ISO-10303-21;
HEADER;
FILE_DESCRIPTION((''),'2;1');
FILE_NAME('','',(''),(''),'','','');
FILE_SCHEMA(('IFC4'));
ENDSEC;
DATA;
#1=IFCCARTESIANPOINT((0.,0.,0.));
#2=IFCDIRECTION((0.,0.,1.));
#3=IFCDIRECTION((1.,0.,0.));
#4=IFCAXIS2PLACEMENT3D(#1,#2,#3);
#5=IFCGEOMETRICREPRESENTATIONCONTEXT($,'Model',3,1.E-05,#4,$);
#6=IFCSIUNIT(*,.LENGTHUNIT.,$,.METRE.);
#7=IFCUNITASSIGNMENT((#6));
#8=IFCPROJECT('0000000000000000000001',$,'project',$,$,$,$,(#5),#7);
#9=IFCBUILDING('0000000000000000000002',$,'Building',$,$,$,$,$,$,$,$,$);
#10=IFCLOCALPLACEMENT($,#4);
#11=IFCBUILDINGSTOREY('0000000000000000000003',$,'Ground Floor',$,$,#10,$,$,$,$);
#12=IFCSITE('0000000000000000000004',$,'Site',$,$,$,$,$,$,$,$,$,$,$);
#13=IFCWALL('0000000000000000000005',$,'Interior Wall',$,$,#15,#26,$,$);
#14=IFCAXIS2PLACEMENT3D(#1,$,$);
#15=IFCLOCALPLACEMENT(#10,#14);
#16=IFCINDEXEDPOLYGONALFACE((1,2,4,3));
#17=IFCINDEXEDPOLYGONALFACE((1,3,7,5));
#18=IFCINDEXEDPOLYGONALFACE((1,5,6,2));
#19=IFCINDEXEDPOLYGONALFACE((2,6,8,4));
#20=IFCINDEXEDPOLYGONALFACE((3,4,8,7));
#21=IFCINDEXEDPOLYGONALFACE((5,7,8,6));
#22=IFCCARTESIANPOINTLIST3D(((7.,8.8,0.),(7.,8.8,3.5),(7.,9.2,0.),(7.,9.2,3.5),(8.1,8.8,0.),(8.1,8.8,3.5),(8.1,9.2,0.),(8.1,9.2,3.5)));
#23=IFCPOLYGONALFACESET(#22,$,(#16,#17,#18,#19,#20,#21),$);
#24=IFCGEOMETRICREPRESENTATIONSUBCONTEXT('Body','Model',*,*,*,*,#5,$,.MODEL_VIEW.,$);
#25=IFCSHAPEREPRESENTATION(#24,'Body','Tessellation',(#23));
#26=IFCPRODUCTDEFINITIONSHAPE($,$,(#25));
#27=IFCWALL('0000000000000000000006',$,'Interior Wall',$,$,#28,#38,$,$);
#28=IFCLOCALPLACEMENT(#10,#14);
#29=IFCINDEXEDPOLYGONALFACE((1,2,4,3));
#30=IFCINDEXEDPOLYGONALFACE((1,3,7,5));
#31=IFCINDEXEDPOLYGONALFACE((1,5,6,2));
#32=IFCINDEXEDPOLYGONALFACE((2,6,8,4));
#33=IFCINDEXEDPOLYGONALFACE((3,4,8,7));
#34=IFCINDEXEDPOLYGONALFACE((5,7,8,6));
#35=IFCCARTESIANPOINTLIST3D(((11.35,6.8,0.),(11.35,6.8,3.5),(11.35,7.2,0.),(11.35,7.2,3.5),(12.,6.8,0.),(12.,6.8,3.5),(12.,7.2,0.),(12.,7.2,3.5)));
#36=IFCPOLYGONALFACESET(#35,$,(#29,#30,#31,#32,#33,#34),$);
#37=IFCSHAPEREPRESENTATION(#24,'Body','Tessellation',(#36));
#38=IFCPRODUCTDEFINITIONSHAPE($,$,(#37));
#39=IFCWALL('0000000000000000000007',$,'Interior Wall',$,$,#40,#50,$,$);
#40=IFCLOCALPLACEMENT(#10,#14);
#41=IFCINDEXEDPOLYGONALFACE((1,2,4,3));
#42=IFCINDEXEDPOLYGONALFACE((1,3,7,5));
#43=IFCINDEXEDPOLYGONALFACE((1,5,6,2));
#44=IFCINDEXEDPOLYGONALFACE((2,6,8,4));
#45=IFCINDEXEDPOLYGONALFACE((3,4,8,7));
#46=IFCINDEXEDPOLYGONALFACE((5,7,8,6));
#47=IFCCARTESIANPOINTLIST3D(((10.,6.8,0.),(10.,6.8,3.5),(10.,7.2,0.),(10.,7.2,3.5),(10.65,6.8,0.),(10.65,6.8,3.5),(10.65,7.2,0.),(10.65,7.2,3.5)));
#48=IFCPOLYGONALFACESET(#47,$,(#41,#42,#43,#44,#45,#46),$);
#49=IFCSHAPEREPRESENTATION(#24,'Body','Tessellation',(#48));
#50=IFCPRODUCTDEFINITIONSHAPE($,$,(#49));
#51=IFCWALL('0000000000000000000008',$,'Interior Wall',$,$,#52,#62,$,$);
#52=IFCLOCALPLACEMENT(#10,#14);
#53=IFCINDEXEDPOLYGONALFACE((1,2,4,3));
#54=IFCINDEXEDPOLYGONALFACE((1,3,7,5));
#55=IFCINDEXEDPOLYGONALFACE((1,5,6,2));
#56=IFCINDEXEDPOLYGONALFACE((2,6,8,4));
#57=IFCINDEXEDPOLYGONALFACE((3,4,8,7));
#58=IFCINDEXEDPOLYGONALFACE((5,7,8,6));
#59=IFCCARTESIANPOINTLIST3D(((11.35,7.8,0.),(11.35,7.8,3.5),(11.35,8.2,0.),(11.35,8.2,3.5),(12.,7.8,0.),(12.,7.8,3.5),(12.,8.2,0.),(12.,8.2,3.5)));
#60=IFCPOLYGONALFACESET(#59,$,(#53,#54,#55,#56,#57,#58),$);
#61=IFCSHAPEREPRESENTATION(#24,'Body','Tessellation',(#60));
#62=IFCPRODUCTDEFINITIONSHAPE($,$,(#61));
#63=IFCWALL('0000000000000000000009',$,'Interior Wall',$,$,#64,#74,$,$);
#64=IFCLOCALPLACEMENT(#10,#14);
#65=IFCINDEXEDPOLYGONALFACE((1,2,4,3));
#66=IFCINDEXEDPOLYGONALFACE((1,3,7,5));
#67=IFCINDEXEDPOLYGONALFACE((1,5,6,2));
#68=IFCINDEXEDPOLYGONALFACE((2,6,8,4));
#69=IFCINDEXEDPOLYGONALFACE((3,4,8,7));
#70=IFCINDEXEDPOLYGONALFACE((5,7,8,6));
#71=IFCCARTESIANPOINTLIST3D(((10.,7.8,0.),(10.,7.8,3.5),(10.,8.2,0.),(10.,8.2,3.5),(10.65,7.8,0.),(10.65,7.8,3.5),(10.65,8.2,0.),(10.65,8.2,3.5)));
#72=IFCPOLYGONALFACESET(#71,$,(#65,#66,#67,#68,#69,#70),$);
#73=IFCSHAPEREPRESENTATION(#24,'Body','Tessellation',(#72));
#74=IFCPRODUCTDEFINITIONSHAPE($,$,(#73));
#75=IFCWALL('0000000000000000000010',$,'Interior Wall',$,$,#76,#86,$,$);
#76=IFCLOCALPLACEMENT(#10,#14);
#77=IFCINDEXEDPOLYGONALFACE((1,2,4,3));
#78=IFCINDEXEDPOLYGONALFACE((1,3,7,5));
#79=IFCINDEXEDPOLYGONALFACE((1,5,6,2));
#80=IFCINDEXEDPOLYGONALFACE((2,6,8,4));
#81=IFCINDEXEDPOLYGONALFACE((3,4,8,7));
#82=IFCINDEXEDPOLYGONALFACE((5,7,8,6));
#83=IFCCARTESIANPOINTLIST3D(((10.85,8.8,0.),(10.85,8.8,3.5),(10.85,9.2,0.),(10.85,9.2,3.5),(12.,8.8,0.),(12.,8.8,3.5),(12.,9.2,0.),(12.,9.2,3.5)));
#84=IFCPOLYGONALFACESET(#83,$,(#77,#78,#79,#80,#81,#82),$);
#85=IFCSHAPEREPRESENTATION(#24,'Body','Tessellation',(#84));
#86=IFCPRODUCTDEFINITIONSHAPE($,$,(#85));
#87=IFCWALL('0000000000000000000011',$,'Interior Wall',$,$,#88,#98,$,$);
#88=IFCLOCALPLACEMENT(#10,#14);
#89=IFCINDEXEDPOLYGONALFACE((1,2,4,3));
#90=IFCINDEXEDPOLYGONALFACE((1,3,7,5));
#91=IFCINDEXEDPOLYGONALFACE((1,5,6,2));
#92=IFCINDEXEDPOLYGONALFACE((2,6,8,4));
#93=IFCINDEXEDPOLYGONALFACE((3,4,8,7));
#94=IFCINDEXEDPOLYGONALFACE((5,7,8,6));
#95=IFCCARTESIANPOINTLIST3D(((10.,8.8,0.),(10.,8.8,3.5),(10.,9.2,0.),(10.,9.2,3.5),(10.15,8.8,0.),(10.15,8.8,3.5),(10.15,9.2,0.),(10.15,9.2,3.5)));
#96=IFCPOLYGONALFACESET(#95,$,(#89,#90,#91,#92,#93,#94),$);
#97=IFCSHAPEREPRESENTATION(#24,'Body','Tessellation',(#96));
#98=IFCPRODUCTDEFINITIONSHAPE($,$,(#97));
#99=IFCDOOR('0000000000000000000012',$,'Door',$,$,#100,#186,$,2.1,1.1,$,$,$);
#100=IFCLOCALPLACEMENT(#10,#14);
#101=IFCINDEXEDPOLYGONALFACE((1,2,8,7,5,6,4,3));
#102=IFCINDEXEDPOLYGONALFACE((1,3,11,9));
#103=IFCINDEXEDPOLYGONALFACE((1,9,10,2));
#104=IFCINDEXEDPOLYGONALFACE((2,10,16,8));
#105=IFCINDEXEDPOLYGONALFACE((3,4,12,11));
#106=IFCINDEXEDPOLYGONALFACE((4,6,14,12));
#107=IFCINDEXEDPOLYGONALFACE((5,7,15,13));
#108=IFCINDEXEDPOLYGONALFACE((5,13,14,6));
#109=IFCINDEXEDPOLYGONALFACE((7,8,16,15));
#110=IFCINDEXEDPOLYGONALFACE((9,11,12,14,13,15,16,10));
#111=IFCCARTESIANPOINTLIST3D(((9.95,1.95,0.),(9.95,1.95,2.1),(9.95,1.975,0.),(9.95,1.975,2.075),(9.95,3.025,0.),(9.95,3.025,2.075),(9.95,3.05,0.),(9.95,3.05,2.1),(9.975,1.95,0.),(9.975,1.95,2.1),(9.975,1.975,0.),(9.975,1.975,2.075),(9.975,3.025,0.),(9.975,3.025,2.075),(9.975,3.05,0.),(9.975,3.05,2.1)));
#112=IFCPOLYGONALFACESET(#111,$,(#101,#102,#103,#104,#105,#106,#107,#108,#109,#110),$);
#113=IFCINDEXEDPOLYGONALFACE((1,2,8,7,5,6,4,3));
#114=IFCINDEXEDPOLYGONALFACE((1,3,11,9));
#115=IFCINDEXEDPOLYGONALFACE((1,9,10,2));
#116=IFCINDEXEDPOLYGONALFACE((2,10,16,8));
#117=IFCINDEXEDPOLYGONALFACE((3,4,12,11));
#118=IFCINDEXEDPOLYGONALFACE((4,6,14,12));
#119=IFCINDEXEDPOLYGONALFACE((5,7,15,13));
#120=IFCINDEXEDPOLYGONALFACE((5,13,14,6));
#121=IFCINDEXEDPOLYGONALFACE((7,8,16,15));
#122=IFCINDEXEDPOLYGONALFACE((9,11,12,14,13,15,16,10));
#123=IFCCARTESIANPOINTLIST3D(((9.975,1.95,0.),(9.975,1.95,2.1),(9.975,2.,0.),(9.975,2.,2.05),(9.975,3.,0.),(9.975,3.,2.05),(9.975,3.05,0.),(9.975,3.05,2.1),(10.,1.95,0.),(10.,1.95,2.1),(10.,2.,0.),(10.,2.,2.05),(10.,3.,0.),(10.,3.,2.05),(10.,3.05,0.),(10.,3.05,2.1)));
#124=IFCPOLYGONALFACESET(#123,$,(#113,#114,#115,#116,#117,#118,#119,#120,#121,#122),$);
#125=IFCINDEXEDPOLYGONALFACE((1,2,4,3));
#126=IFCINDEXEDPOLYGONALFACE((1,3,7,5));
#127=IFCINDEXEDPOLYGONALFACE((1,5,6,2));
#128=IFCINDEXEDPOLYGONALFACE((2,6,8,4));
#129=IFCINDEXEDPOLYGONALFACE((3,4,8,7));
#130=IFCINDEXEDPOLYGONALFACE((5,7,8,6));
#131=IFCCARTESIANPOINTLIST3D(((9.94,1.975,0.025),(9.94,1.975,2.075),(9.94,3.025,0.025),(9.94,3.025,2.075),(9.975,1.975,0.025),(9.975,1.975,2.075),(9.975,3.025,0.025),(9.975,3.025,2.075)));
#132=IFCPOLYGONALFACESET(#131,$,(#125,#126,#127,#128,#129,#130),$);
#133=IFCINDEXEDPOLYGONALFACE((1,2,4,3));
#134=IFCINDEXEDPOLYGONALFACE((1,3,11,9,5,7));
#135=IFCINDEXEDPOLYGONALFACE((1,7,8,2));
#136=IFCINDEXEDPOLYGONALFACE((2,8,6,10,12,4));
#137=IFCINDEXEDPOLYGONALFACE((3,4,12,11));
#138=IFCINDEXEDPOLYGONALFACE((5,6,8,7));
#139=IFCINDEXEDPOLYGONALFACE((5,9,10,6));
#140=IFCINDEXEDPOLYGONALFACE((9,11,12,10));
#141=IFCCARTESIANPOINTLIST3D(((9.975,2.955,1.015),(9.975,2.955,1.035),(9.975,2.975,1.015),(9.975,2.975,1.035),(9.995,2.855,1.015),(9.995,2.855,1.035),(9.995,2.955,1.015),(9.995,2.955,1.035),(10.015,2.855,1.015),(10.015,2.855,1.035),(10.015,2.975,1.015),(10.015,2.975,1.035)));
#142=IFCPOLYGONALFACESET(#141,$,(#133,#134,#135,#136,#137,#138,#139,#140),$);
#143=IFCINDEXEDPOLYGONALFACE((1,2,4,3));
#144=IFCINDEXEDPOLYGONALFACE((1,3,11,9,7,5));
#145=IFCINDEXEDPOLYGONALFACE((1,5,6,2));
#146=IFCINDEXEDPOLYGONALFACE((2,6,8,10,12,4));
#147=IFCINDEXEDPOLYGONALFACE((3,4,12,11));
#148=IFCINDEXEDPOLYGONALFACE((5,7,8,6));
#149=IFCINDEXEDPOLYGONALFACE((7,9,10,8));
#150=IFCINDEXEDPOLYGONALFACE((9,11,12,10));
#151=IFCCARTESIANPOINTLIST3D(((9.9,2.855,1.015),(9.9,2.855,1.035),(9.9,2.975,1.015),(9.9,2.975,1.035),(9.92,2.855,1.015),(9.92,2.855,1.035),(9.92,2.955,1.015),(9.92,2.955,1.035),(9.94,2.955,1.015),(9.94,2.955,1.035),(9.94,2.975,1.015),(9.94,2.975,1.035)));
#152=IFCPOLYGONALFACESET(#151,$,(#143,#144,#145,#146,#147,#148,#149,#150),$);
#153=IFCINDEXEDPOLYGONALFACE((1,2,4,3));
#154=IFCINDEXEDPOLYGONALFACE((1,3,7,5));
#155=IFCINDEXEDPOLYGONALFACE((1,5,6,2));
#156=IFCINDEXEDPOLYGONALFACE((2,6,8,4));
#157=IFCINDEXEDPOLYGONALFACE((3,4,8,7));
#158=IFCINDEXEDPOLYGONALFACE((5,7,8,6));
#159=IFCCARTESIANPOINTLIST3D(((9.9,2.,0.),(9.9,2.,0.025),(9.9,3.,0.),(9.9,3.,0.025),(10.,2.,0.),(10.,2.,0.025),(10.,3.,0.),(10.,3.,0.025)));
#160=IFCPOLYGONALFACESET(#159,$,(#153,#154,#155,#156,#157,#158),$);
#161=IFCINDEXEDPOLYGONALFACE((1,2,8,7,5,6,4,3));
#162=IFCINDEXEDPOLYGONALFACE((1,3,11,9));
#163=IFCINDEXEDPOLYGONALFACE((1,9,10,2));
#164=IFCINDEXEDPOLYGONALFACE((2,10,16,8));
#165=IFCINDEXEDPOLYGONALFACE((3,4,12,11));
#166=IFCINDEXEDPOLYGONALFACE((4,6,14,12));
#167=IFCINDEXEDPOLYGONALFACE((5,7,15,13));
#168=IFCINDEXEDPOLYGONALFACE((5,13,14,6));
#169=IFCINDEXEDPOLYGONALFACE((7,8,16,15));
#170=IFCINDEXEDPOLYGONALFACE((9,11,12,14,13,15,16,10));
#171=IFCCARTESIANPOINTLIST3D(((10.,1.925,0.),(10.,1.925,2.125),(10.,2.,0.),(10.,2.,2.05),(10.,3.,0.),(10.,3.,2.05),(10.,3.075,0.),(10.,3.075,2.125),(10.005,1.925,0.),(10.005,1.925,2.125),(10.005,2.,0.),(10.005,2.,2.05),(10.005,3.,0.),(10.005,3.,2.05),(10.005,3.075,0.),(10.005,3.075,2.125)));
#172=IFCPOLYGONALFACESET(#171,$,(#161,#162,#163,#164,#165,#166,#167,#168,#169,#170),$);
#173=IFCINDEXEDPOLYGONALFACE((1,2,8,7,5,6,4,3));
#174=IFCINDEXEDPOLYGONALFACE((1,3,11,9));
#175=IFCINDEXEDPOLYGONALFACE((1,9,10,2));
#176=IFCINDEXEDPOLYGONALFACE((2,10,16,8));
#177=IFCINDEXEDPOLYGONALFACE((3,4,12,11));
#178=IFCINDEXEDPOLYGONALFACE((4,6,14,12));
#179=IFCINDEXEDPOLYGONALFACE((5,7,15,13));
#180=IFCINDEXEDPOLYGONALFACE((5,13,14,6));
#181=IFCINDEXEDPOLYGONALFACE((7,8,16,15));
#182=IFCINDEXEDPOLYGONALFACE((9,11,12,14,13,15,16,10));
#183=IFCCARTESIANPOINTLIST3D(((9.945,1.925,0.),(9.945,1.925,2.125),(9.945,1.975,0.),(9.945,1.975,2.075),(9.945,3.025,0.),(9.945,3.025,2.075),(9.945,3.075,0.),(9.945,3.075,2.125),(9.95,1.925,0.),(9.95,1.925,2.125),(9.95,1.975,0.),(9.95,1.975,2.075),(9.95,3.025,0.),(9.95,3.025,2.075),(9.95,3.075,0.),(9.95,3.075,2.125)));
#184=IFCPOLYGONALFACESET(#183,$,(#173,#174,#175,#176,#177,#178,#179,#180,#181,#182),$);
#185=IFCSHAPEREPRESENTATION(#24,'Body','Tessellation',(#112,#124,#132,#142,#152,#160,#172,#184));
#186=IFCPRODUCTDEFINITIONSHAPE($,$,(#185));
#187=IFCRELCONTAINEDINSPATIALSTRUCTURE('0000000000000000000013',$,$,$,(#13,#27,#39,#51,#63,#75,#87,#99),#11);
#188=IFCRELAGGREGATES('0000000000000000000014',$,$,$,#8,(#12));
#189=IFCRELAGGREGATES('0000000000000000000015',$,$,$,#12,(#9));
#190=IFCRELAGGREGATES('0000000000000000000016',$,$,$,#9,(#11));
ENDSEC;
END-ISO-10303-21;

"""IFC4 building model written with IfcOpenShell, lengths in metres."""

from ifc_helpers import new_model, si_unit, frame, origin_with_axes, place, context, subcontext, project, spatial, line, indexed_curve, outline, extrude, element, save


model = new_model("IFC4")

# Units and contexts
model_context = context("Model", 3, precision=1e-05, world=origin_with_axes())
body_context = subcontext(model_context, "Body", "Model", "MODEL_VIEW")
ifc_project = project(units=[si_unit("LENGTHUNIT", "METRE")], contexts=[model_context])

# Site, building, storey
site = spatial("IfcSite", under=ifc_project, Name="Site")
building = spatial("IfcBuilding", under=site, Name="Building")
storey_placement = place(None, origin_with_axes())
storey = spatial("IfcBuildingStorey", under=building, at=storey_placement, Name="Ground Floor")

# Walls
for number, where, z_axis, x_axis, name in (
    (1, (8.1, 9.0, 0.0), (0.0, 0.0, 1.0), (-1.0, 0.0, 0.0), "Interior Wall"),
):
    element("IfcWall", number, at=place(storey_placement, frame(where, z_axis=z_axis, x_axis=x_axis)), inside=storey, Name=name, context=body_context, shape_type="SweptSolid", body=[
        extrude(outline(indexed_curve([(0.0, 0.0), (0.0, 0.4), (1.1, 0.4), (1.1, 0.0), (0.0, 0.0)], self_intersect=False)), frame((0.0, -0.2, 0.0), z_axis=(0.0, 0.0, 1.0), x_axis=(1.0, 0.0, 0.0)), (0.0, 0.0, 1.0), 3.5),
    ])
for number, where, z_axis, x_axis, name in (
    (2, (12.0, 7.0, 0.0), (0.0, 0.0, 1.0), (-1.0, 0.0, 0.0), "Interior Wall"),
    (3, (10.65, 7.0, 0.0), (0.0, 0.0, 1.0), (-1.0, 0.0, 0.0), "Interior Wall"),
    (4, (12.0, 8.0, 0.0), (0.0, 0.0, 1.0), (-1.0, 0.0, 0.0), "Interior Wall"),
    (5, (10.65, 8.0, 0.0), (0.0, 0.0, 1.0), (-1.0, 0.0, 0.0), "Interior Wall"),
):
    element("IfcWall", number, at=place(storey_placement, frame(where, z_axis=z_axis, x_axis=x_axis)), inside=storey, Name=name, context=body_context, shape_type="SweptSolid", body=[
        extrude(outline(indexed_curve([(0.0, 0.0), (0.0, 0.4), (0.65, 0.4), (0.65, 0.0), (0.0, 0.0)], self_intersect=False)), frame((0.0, -0.2, 0.0), z_axis=(0.0, 0.0, 1.0), x_axis=(1.0, 0.0, 0.0)), (0.0, 0.0, 1.0), 3.5),
    ])
wall_1_placement = place(storey_placement, frame((12.0, 9.0, 0.0), z_axis=(0.0, 0.0, 1.0), x_axis=(-1.0, 0.0, 0.0)))
element("IfcWall", 6, at=wall_1_placement, inside=storey, Name="Interior Wall", context=body_context, shape_type="SweptSolid", body=[
    extrude(outline(indexed_curve([(0.0, 0.0), (0.0, 0.4), (1.15, 0.4), (1.15, 0.0), (0.0, 0.0)], self_intersect=False)), frame((0.0, -0.2, 0.0), z_axis=(0.0, 0.0, 1.0), x_axis=(1.0, 0.0, 0.0)), (0.0, 0.0, 1.0), 3.5),
])
wall_2_placement = place(storey_placement, frame((10.15, 9.0, 0.0), z_axis=(0.0, 0.0, 1.0), x_axis=(-1.0, 0.0, 0.0)))
element("IfcWall", 7, at=wall_2_placement, inside=storey, Name="Interior Wall", context=body_context, shape_type="SweptSolid", body=[
    extrude(outline(indexed_curve([(0.0, 0.0), (0.0, 0.4), (0.15, 0.4), (0.15, 0.0), (0.0, 0.0)], self_intersect=False)), frame((0.0, -0.2, 0.0), z_axis=(0.0, 0.0, 1.0), x_axis=(1.0, 0.0, 0.0)), (0.0, 0.0, 1.0), 3.5),
])

# Door
door_1_placement = place(storey_placement, frame((10.0, 1.95, 0.0), z_axis=(0.0, 0.0, 1.0), x_axis=(0.0, 1.0, 0.0)))
element("IfcDoor", 8, at=door_1_placement, inside=storey, Name="Door", OverallHeight=2.1, OverallWidth=1.1, context=body_context, shape_type="SweptSolid", body=[
    extrude(outline(indexed_curve([(0.0, 0.0), (0.0, 2.1), (1.1, 2.1), (1.1, 0.0), (1.075, 0.0), (1.075, 2.075), (0.025, 2.075), (0.025, 0.0)], segments=[line(1, 2, 3, 4, 5, 6, 7, 8, 1)])), frame((0.0, 0.025, 0.0), z_axis=(0.0, -1.0, 0.0), x_axis=(1.0, 0.0, 0.0)), (0.0, 0.0, -1.0), 0.025),
    extrude(outline(indexed_curve([(0.0, 0.0), (0.0, 2.1), (1.1, 2.1), (1.1, 0.0), (1.05, 0.0), (1.05, 2.05), (0.05, 2.05), (0.05, 0.0)], segments=[line(1, 2, 3, 4, 5, 6, 7, 8, 1)])), frame((0.0, 0.0, 0.0), z_axis=(0.0, -1.0, 0.0), x_axis=(1.0, 0.0, 0.0)), (0.0, 0.0, -1.0), 0.025),
    extrude(outline(indexed_curve([(0.0, 0.0), (1.05, 0.0), (1.05, 0.035), (0.0, 0.035)], segments=[line(1, 2, 3, 4, 1)])), frame((0.025, 0.025, 0.025), z_axis=(0.0, 0.0, 1.0), x_axis=(1.0, 0.0, 0.0)), (0.0, 0.0, 1.0), 2.05),
    extrude(outline(indexed_curve([(0.0, 0.0), (0.0, -0.04), (-0.12, -0.04), (-0.12, -0.02), (-0.02, -0.02), (-0.02, 0.0)], segments=[line(1, 2, 3, 4, 5, 6, 1)])), frame((1.025, 0.025, 1.015), z_axis=(0.0, 0.0, 1.0), x_axis=(1.0, 0.0, 0.0)), (0.0, 0.0, 1.0), 0.02),
    extrude(outline(indexed_curve([(0.0, 0.0), (0.0, 0.04), (-0.12, 0.04), (-0.12, 0.02), (-0.02, 0.02), (-0.02, 0.0)], segments=[line(1, 2, 3, 4, 5, 6, 1)])), frame((1.025, 0.06, 1.015), z_axis=(0.0, 0.0, 1.0), x_axis=(1.0, 0.0, 0.0)), (0.0, 0.0, 1.0), 0.02),
    extrude(outline(indexed_curve([(0.0, 0.0), (1.0, 0.0), (1.0, 0.1), (0.0, 0.1)], segments=[line(1, 2, 3, 4, 1)])), frame((0.05, 0.0, 0.0), z_axis=(0.0, 0.0, 1.0), x_axis=(1.0, 0.0, 0.0)), (0.0, 0.0, 1.0), 0.025),
    extrude(outline(indexed_curve([(0.0, 0.0), (0.0, 2.125), (1.15, 2.125), (1.15, 0.0), (1.075, 0.0), (1.075, 2.05), (0.075, 2.05), (0.075, 0.0)], segments=[line(1, 2, 3, 4, 5, 6, 7, 8, 1)])), frame((-0.025, -0.005, 0.0), z_axis=(0.0, -1.0, 0.0), x_axis=(1.0, 0.0, 0.0)), (0.0, 0.0, -1.0), 0.005),
    extrude(outline(indexed_curve([(0.0, 0.0), (0.0, 2.125), (1.15, 2.125), (1.15, 0.0), (1.1, 0.0), (1.1, 2.075), (0.05, 2.075), (0.05, 0.0)], segments=[line(1, 2, 3, 4, 5, 6, 7, 8, 1)])), frame((-0.025, 0.05, 0.0), z_axis=(0.0, -1.0, 0.0), x_axis=(1.0, 0.0, 0.0)), (0.0, 0.0, -1.0), 0.005),
])

save(model, "model.ifc")
